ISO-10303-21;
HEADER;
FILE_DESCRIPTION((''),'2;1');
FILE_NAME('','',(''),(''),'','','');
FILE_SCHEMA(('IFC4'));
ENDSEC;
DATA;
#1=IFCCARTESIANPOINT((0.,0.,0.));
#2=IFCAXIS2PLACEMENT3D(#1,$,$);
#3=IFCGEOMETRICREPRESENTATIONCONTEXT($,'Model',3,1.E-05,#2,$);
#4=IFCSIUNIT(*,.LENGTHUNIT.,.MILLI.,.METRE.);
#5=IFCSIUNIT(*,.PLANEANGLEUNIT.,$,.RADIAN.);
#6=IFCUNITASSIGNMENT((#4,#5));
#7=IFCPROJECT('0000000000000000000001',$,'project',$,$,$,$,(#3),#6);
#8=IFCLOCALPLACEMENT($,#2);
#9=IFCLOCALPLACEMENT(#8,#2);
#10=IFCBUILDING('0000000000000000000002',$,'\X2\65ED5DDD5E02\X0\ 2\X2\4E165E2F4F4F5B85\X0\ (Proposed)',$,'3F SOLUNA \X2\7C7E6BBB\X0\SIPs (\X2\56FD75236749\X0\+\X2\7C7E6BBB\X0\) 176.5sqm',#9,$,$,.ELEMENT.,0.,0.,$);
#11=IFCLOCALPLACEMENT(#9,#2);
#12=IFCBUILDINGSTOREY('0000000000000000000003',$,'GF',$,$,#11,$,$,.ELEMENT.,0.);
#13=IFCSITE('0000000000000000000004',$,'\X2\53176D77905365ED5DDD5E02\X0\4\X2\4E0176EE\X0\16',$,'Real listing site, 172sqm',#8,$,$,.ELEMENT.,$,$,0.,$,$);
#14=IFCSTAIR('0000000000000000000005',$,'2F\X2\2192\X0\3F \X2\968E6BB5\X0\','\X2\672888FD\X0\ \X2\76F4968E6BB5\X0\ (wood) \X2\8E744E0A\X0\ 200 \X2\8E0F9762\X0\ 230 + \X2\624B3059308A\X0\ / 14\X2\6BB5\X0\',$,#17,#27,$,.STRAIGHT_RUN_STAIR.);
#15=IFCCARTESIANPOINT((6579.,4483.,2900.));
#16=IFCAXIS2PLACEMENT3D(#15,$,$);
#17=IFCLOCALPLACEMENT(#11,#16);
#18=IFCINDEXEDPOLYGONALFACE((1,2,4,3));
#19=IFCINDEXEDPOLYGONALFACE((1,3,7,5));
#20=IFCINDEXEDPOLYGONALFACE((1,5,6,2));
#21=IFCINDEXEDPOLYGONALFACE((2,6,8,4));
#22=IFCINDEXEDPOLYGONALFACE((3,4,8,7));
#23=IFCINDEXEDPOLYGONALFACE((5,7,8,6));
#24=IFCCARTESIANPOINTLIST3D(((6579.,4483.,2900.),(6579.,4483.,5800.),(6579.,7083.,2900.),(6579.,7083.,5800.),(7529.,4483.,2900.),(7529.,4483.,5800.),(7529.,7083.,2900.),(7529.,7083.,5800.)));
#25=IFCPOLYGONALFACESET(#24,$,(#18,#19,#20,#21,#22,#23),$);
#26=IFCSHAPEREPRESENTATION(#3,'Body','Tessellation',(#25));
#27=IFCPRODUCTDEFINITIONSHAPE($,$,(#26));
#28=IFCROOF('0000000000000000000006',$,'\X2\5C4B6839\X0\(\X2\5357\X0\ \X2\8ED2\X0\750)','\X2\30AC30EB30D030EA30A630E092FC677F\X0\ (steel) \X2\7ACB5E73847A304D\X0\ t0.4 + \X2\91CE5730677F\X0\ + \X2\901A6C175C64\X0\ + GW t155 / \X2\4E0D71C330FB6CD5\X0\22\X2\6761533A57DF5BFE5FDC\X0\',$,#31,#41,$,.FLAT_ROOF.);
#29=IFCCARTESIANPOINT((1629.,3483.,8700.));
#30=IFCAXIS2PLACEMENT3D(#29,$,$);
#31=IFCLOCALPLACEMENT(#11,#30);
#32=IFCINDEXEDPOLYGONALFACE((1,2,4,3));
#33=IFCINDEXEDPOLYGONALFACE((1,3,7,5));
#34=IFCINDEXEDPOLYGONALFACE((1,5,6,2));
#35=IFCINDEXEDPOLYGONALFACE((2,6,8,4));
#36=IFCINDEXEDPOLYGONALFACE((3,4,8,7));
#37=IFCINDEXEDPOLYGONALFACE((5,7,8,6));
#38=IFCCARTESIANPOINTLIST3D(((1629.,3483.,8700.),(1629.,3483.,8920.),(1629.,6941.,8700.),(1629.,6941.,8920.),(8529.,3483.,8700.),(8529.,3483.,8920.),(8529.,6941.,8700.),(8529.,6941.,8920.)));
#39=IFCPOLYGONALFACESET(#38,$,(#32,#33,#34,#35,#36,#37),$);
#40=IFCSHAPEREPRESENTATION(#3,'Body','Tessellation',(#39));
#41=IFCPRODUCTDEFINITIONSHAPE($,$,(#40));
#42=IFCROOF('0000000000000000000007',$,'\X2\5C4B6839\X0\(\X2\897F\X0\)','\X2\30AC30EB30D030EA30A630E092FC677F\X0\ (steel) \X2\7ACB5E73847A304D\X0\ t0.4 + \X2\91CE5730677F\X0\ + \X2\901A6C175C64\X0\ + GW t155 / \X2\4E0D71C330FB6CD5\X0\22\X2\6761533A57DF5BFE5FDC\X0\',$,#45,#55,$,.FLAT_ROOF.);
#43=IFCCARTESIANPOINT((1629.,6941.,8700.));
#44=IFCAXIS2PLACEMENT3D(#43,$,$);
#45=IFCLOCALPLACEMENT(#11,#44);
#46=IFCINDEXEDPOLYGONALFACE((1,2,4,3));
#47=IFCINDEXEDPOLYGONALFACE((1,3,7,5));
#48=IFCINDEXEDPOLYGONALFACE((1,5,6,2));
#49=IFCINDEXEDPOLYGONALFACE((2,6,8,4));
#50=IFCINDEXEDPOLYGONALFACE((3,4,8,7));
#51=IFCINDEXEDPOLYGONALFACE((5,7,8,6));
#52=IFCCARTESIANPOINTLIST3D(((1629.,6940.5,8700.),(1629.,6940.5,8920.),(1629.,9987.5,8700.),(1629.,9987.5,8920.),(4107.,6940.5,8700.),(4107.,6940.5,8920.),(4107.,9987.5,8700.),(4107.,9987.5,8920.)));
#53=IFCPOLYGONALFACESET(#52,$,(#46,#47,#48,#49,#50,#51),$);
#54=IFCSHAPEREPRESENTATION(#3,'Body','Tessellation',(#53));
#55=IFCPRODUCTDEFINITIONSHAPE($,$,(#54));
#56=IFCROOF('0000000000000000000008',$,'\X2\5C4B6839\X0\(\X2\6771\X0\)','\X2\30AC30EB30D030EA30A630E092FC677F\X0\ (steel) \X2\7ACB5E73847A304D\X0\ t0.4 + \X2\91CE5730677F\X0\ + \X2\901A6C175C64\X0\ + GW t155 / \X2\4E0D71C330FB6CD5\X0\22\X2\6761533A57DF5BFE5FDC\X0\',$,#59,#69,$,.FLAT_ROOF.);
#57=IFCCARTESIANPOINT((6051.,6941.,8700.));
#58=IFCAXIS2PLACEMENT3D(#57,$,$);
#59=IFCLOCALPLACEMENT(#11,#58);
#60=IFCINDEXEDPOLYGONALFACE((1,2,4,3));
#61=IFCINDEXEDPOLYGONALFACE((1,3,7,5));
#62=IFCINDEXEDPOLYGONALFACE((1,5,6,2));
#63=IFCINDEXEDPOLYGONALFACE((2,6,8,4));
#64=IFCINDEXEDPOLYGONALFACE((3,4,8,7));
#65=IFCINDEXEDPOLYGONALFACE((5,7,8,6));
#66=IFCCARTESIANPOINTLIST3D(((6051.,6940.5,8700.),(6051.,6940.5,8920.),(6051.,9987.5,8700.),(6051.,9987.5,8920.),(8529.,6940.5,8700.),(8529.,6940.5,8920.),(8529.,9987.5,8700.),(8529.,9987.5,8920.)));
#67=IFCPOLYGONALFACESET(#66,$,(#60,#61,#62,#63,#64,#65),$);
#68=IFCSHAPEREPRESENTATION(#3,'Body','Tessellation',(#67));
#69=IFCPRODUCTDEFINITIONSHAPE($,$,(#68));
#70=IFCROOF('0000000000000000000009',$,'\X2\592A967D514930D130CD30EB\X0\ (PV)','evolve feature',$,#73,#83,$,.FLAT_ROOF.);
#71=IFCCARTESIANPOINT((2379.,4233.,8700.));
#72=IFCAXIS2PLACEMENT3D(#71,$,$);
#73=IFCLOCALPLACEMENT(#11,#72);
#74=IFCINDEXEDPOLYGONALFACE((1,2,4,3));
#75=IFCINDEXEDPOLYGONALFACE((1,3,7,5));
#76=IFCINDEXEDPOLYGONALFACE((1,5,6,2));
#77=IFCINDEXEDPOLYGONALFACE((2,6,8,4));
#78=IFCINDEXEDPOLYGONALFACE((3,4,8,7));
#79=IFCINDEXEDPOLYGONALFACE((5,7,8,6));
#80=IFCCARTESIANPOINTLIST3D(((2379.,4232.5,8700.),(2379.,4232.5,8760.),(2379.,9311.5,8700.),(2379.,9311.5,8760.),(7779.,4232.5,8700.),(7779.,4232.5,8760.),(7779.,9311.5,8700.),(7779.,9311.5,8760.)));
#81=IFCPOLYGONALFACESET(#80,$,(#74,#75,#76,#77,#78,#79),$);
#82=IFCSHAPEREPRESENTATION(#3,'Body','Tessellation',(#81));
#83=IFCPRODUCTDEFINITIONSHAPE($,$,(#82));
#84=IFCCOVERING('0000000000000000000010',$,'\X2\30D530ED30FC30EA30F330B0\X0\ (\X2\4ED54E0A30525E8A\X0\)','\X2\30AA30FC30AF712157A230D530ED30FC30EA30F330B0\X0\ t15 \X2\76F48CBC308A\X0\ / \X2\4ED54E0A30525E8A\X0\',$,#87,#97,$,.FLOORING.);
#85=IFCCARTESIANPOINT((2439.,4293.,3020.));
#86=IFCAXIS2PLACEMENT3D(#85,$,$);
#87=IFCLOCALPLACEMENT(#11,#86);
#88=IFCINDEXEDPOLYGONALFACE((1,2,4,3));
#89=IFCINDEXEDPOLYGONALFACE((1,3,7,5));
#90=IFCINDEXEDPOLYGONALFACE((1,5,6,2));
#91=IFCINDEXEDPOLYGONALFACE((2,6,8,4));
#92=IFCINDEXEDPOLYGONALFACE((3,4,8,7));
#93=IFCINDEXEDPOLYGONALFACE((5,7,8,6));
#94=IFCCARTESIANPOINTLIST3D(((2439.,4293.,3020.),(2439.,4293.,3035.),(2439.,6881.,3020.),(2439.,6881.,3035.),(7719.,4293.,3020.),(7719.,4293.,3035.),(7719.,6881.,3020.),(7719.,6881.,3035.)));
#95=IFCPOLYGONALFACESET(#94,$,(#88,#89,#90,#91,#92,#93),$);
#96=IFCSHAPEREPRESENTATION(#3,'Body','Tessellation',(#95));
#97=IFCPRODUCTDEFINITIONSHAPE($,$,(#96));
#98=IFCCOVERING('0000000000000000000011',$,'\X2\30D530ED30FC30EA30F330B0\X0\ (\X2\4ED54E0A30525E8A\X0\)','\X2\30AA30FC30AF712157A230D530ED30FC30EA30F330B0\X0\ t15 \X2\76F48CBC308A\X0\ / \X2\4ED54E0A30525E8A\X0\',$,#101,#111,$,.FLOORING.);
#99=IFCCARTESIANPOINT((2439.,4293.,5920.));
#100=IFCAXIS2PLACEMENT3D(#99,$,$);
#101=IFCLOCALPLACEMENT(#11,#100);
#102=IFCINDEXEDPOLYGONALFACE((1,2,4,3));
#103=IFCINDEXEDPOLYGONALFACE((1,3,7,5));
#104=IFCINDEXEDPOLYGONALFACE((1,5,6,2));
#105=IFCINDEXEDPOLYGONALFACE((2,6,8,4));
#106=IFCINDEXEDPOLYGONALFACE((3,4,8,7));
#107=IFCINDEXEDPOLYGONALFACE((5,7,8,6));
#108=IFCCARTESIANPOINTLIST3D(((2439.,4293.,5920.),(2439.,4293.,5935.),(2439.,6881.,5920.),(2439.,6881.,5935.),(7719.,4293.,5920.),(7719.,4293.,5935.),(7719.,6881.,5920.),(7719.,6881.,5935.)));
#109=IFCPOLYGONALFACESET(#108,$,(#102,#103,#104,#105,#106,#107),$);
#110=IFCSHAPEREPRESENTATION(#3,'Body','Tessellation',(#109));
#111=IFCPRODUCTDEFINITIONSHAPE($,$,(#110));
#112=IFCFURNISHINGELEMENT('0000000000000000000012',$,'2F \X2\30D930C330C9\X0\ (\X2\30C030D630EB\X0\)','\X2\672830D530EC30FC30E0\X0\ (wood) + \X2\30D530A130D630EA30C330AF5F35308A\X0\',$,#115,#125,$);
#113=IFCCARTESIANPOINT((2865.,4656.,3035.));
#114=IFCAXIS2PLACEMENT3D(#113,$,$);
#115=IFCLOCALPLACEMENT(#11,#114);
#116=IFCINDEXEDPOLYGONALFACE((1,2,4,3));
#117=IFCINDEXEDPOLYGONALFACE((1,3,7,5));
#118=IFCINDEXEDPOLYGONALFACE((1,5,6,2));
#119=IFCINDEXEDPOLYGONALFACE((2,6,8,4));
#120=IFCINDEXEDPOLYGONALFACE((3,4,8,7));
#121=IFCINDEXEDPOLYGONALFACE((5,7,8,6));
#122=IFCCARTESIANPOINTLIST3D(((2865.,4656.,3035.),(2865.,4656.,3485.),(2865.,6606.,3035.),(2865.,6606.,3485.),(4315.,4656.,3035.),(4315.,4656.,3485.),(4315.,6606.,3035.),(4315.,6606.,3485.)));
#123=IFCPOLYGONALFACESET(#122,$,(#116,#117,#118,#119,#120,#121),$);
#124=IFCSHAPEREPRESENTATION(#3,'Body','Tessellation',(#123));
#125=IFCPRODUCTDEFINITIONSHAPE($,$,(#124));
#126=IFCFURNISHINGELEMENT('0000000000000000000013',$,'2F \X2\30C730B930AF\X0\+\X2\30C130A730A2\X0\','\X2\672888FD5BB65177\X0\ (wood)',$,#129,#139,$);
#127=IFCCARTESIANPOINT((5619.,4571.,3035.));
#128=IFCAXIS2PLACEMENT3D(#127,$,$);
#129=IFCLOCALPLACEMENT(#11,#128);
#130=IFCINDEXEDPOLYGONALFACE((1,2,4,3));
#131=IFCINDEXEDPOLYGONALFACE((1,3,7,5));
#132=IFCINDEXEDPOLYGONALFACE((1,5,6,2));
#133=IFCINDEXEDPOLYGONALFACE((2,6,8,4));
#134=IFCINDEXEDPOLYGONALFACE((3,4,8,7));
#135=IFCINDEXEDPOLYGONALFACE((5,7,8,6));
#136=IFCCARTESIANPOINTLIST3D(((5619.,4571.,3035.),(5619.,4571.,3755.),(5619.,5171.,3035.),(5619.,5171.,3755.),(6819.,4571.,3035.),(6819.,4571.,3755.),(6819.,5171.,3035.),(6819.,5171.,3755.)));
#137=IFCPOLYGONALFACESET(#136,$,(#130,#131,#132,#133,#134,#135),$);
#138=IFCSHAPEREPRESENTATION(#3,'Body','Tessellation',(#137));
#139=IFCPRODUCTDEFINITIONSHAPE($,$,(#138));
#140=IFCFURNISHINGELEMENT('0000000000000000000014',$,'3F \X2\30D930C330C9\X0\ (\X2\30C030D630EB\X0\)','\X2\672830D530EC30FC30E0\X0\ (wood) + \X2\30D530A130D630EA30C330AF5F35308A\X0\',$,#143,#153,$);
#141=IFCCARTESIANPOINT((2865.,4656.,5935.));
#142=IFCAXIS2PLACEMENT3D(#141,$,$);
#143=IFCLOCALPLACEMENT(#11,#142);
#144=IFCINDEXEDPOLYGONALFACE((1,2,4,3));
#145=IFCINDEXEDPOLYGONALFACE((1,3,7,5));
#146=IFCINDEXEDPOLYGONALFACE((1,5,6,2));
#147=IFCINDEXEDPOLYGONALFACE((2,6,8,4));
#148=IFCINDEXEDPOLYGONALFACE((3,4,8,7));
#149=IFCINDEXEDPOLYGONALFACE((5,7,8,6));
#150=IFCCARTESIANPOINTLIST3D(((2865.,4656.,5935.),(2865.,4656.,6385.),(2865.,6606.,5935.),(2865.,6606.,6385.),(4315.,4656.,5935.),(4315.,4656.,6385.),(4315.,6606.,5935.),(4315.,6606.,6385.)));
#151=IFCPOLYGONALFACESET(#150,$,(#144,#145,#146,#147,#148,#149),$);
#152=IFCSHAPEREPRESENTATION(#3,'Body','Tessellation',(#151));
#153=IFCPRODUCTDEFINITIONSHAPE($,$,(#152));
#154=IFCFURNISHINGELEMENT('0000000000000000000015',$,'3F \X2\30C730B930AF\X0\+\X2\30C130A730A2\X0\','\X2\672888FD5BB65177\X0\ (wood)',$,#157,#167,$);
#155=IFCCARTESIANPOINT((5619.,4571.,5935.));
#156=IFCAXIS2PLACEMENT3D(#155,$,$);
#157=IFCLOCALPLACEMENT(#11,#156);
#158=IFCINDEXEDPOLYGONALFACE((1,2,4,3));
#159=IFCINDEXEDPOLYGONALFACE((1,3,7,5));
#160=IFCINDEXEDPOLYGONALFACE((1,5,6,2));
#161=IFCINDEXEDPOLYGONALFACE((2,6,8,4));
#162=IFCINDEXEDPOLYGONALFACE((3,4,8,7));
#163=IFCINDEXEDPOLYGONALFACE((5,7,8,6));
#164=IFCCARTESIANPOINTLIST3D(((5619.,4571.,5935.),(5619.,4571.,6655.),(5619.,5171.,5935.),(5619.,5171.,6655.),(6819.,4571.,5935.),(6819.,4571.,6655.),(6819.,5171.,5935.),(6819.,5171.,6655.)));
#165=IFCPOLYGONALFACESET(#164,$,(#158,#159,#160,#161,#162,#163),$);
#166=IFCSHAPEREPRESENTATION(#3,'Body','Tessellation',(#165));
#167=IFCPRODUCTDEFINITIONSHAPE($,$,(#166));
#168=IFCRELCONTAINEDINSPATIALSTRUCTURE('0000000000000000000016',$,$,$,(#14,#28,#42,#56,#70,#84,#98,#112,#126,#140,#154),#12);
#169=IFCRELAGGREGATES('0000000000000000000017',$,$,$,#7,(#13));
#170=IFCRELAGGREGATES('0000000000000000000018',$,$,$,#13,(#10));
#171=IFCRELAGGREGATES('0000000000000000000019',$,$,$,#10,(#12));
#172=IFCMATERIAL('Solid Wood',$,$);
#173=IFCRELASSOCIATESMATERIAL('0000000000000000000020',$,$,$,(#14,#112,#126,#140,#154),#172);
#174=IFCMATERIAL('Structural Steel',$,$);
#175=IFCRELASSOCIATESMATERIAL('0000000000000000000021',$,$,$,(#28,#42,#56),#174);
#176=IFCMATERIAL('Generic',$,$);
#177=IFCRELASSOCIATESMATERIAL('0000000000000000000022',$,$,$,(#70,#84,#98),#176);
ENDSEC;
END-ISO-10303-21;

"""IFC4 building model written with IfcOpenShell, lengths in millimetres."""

from ifc_helpers import new_model, si_unit, frame, frame_2d, origin, place, context, project, spatial, rectangle, extrude, material, element, save


model = new_model("IFC4")

# Units and contexts
model_context = context("Model", 3, precision=1e-05, world=origin())
ifc_project = project(units=[si_unit("LENGTHUNIT", "METRE", prefix="MILLI"), si_unit("PLANEANGLEUNIT", "RADIAN")], contexts=[model_context])

# Site, building, storey
site_placement = place(None, origin())
site = spatial("IfcSite", under=ifc_project, at=site_placement, Name="北海道旭川市4丁目16", ObjectType="Real listing site, 172sqm", CompositionType="ELEMENT", RefElevation=0.0)
building_placement = place(site_placement, origin())
building = spatial("IfcBuilding", under=site, at=building_placement, Name="旭川市 2世帯住宅 (Proposed)", ObjectType="3F SOLUNA 籾殻SIPs (国産杉+籾殻) 176.5sqm", CompositionType="ELEMENT", ElevationOfRefHeight=0.0, ElevationOfTerrain=0.0)
storey_placement = place(building_placement, origin())
storey = spatial("IfcBuildingStorey", under=building, at=storey_placement, Name="GF", CompositionType="ELEMENT", Elevation=0.0)

# Shared definitions
ifc_material_1 = material(Name="Solid Wood")

# Stair
stair_placement = place(storey_placement, frame((6579.0, 4483.0, 2900.0)))
element("IfcStair", 1, at=stair_placement, inside=storey, material=ifc_material_1, Name="2F→3F 階段", Description="木製 直階段 (wood) 蹴上 200 踏面 230 + 手すり / 14段", PredefinedType="STRAIGHT_RUN_STAIR", context=model_context, shape_type="SweptSolid", body=[
    extrude(rectangle(XDim=950.0, YDim=2600.0, at=frame_2d((475.0, 1300.0))), frame((6579.0, 4483.0, 2900.0)), (0.0, 0.0, 1.0), 2900.0),
])

# Roofs
ifc_material_2 = material(Name="Structural Steel")
roof_1_placement = place(storey_placement, frame((1629.0, 3483.0, 8700.0)))
element("IfcRoof", 2, at=roof_1_placement, inside=storey, material=ifc_material_2, Name="屋根(南 軒750)", Description="ガルバリウム鋼板 (steel) 立平葺き t0.4 + 野地板 + 通気層 + GW t155 / 不燃・法22条区域対応", PredefinedType="FLAT_ROOF", context=model_context, shape_type="SweptSolid", body=[
    extrude(rectangle(XDim=6900.0, YDim=3458.0, at=frame_2d((3450.0, 1729.0))), frame((1629.0, 3483.0, 8700.0)), (0.0, 0.0, 1.0), 220.0),
])
roof_2_placement = place(storey_placement, frame((1629.0, 6941.0, 8700.0)))
element("IfcRoof", 3, at=roof_2_placement, inside=storey, material=ifc_material_2, Name="屋根(西)", Description="ガルバリウム鋼板 (steel) 立平葺き t0.4 + 野地板 + 通気層 + GW t155 / 不燃・法22条区域対応", PredefinedType="FLAT_ROOF", context=model_context, shape_type="SweptSolid", body=[
    extrude(rectangle(XDim=2478.0, YDim=3047.0, at=frame_2d((1239.0, 1523.0))), frame((1629.0, 6941.0, 8700.0)), (0.0, 0.0, 1.0), 220.0),
])
roof_3_placement = place(storey_placement, frame((6051.0, 6941.0, 8700.0)))
element("IfcRoof", 4, at=roof_3_placement, inside=storey, material=ifc_material_2, Name="屋根(東)", Description="ガルバリウム鋼板 (steel) 立平葺き t0.4 + 野地板 + 通気層 + GW t155 / 不燃・法22条区域対応", PredefinedType="FLAT_ROOF", context=model_context, shape_type="SweptSolid", body=[
    extrude(rectangle(XDim=2478.0, YDim=3047.0, at=frame_2d((1239.0, 1523.0))), frame((6051.0, 6941.0, 8700.0)), (0.0, 0.0, 1.0), 220.0),
])
ifc_material_3 = material(Name="Generic")
roof_4_placement = place(storey_placement, frame((2379.0, 4233.0, 8700.0)))
element("IfcRoof", 5, at=roof_4_placement, inside=storey, material=ifc_material_3, Name="太陽光パネル (PV)", Description="evolve feature", PredefinedType="FLAT_ROOF", context=model_context, shape_type="SweptSolid", body=[
    extrude(rectangle(XDim=5400.0, YDim=5079.0, at=frame_2d((2700.0, 2539.0))), frame((2379.0, 4233.0, 8700.0)), (0.0, 0.0, 1.0), 60.0),
])

# Coverings
covering_1_placement = place(storey_placement, frame((2439.0, 4293.0, 3020.0)))
element("IfcCovering", 6, at=covering_1_placement, inside=storey, material=ifc_material_3, Name="フローリング (仕上げ床)", Description="オーク無垢フローリング t15 直貼り / 仕上げ床", PredefinedType="FLOORING", context=model_context, shape_type="SweptSolid", body=[
    extrude(rectangle(XDim=5280.0, YDim=2588.0, at=frame_2d((2640.0, 1294.0))), frame((2439.0, 4293.0, 3020.0)), (0.0, 0.0, 1.0), 15.0),
])
covering_2_placement = place(storey_placement, frame((2439.0, 4293.0, 5920.0)))
element("IfcCovering", 7, at=covering_2_placement, inside=storey, material=ifc_material_3, Name="フローリング (仕上げ床)", Description="オーク無垢フローリング t15 直貼り / 仕上げ床", PredefinedType="FLOORING", context=model_context, shape_type="SweptSolid", body=[
    extrude(rectangle(XDim=5280.0, YDim=2588.0, at=frame_2d((2640.0, 1294.0))), frame((2439.0, 4293.0, 5920.0)), (0.0, 0.0, 1.0), 15.0),
])

# Furnishing elements
furnishing_1_placement = place(storey_placement, frame((2865.0, 4656.0, 3035.0)))
element("IfcFurnishingElement", 8, at=furnishing_1_placement, inside=storey, material=ifc_material_1, Name="2F ベッド (ダブル)", Description="木フレーム (wood) + ファブリック張り", context=model_context, shape_type="SweptSolid", body=[
    extrude(rectangle(XDim=1450.0, YDim=1950.0, at=frame_2d((725.0, 975.0))), frame((2865.0, 4656.0, 3035.0)), (0.0, 0.0, 1.0), 450.0),
])
furnishing_2_placement = place(storey_placement, frame((5619.0, 4571.0, 3035.0)))
element("IfcFurnishingElement", 9, at=furnishing_2_placement, inside=storey, material=ifc_material_1, Name="2F デスク+チェア", Description="木製家具 (wood)", context=model_context, shape_type="SweptSolid", body=[
    extrude(rectangle(XDim=1200.0, YDim=600.0, at=frame_2d((600.0, 300.0))), frame((5619.0, 4571.0, 3035.0)), (0.0, 0.0, 1.0), 720.0),
])
furnishing_3_placement = place(storey_placement, frame((2865.0, 4656.0, 5935.0)))
element("IfcFurnishingElement", 10, at=furnishing_3_placement, inside=storey, material=ifc_material_1, Name="3F ベッド (ダブル)", Description="木フレーム (wood) + ファブリック張り", context=model_context, shape_type="SweptSolid", body=[
    extrude(rectangle(XDim=1450.0, YDim=1950.0, at=frame_2d((725.0, 975.0))), frame((2865.0, 4656.0, 5935.0)), (0.0, 0.0, 1.0), 450.0),
])
furnishing_4_placement = place(storey_placement, frame((5619.0, 4571.0, 5935.0)))
element("IfcFurnishingElement", 11, at=furnishing_4_placement, inside=storey, material=ifc_material_1, Name="3F デスク+チェア", Description="木製家具 (wood)", context=model_context, shape_type="SweptSolid", body=[
    extrude(rectangle(XDim=1200.0, YDim=600.0, at=frame_2d((600.0, 300.0))), frame((5619.0, 4571.0, 5935.0)), (0.0, 0.0, 1.0), 720.0),
])

save(model, "model.ifc")
